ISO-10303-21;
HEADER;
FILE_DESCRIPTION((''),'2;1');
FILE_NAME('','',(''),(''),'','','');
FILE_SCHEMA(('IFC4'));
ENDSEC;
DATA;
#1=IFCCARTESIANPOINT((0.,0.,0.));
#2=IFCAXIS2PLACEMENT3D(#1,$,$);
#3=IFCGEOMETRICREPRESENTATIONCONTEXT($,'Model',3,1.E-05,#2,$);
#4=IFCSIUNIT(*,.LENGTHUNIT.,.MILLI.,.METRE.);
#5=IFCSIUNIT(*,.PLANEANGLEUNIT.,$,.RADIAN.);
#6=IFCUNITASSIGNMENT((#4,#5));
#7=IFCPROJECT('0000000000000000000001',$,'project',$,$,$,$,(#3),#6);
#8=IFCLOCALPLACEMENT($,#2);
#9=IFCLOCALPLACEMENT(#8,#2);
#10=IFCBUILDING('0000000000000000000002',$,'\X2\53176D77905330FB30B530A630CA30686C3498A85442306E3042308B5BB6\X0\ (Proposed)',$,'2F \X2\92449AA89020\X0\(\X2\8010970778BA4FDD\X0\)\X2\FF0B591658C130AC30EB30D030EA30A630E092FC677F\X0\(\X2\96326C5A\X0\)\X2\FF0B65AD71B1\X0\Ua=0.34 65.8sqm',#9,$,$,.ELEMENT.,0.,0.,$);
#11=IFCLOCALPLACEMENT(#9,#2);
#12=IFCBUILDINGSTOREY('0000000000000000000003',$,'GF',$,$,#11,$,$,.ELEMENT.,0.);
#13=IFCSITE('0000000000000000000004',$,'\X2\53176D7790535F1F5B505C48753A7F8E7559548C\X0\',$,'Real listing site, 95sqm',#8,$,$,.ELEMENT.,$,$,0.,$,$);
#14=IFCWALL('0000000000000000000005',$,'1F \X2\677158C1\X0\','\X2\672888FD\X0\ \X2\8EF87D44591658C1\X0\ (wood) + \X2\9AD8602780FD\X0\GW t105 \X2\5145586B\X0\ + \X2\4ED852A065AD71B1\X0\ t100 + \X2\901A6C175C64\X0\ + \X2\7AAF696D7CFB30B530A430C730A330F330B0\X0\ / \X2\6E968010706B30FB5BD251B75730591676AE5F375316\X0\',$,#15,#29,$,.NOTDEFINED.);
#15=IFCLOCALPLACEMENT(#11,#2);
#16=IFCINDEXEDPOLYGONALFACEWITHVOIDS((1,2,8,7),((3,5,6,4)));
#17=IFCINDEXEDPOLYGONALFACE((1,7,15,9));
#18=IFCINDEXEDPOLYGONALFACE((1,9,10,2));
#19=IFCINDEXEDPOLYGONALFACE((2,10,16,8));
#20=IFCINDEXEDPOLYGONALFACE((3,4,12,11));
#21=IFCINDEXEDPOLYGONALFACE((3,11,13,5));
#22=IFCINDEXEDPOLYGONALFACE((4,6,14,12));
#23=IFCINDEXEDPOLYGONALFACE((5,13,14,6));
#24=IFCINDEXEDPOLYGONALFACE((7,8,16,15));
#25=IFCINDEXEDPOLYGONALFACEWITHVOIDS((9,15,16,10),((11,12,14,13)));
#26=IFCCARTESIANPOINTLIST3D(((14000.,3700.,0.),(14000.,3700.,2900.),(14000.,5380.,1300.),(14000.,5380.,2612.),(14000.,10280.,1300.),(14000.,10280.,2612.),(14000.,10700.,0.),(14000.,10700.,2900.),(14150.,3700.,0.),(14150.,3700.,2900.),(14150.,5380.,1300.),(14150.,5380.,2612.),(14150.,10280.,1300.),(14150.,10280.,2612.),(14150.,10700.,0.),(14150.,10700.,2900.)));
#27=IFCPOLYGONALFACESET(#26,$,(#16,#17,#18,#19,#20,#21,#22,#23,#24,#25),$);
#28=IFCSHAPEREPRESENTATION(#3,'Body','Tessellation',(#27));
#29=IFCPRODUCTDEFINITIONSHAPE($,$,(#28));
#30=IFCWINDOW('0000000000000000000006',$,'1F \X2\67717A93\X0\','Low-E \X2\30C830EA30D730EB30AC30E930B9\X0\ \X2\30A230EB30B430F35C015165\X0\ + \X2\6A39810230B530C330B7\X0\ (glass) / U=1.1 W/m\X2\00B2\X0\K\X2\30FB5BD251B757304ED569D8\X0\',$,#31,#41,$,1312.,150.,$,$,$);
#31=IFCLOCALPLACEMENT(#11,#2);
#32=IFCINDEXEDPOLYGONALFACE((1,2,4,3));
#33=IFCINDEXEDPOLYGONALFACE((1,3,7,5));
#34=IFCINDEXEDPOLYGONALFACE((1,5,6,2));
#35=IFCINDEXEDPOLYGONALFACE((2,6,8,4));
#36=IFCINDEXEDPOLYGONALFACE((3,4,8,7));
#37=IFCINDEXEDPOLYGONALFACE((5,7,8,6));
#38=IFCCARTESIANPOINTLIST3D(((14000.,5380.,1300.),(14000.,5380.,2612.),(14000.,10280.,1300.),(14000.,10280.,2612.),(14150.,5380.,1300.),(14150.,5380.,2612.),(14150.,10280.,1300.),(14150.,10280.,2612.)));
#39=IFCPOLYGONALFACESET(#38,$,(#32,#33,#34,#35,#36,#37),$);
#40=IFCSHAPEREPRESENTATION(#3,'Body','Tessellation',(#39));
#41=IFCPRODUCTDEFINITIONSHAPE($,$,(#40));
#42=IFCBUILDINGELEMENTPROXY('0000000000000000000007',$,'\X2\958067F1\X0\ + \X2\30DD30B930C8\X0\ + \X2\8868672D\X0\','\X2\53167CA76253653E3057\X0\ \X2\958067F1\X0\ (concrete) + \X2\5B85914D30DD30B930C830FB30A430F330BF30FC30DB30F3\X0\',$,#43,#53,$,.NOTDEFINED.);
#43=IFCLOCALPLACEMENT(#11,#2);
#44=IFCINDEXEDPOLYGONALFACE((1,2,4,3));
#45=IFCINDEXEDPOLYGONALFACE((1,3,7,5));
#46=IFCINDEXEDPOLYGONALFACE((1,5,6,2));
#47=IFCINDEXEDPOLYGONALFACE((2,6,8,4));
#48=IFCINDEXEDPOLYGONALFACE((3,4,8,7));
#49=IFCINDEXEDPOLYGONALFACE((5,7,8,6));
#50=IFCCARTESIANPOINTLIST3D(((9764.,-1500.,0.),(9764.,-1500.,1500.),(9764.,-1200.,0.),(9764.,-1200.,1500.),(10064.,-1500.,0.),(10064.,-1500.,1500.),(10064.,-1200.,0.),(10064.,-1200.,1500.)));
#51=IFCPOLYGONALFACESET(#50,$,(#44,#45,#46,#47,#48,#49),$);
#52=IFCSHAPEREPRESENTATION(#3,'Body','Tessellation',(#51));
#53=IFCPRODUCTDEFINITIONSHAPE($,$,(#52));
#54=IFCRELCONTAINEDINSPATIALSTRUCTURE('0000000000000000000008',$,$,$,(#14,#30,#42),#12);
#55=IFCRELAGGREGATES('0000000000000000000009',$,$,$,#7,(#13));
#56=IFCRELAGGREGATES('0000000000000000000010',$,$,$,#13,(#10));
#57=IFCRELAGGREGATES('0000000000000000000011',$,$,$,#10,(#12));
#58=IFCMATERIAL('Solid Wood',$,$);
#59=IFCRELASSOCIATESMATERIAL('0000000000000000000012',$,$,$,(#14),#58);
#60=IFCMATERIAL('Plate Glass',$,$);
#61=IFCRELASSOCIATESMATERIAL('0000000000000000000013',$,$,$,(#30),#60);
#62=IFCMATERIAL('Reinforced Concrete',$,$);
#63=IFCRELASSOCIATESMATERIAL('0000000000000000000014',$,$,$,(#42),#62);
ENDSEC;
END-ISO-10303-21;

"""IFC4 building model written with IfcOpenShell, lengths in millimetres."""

from ifc_helpers import new_model, si_unit, frame, frame_2d, origin, place, context, project, spatial, rectangle, extrude, material, element, fill, save


model = new_model("IFC4")

# Units and contexts
model_context = context("Model", 3, precision=1e-05, world=origin())
ifc_project = project(units=[si_unit("LENGTHUNIT", "METRE", prefix="MILLI"), si_unit("PLANEANGLEUNIT", "RADIAN")], contexts=[model_context])

# Site, building, storey
site_placement = place(None, origin())
site = spatial("IfcSite", under=ifc_project, at=site_placement, Name="北海道弟子屈町美留和", ObjectType="Real listing site, 95sqm", CompositionType="ELEMENT", RefElevation=0.0)
building_placement = place(site_placement, origin())
building = spatial("IfcBuilding", under=site, at=building_placement, Name="北海道・サウナと水風呂のある家 (Proposed)", ObjectType="2F 鉄骨造(耐震確保)＋外壁ガルバリウム鋼板(防汚)＋断熱Ua=0.34 65.8sqm", CompositionType="ELEMENT", ElevationOfRefHeight=0.0, ElevationOfTerrain=0.0)
storey_placement = place(building_placement, origin())
storey = spatial("IfcBuildingStorey", under=building, at=storey_placement, Name="GF", CompositionType="ELEMENT", Elevation=0.0)

# Shared definitions
ifc_material_1 = material(Name="Solid Wood")

# Wall, opening, window
wall_1_placement = place(storey_placement, frame((7000.0, 1850.0, 0.0)))
wall_1 = element("IfcWall", 1, at=wall_1_placement, inside=storey, material=ifc_material_1, Name="1F 東壁", Description="木製 軸組外壁 (wood) + 高性能GW t105 充填 + 付加断熱 t100 + 通気層 + 窯業系サイディング / 準耐火・寒冷地外皮強化", PredefinedType="NOTDEFINED", context=model_context, shape_type="SweptSolid", body=[
    extrude(rectangle(XDim=150.0, YDim=7000.0, at=frame_2d((75.0, 3500.0))), frame((7000.0, 1850.0, 0.0)), (0.0, 0.0, 1.0), 2900.0),
])
opening_1_placement = place(storey_placement, frame((7000.0, 2690.0, 650.0)))
opening_1 = element("IfcOpeningElement", 2, at=opening_1_placement, cuts=wall_1, PredefinedType="NOTDEFINED", context=model_context, shape_type="SweptSolid", body=[
    extrude(rectangle(XDim=150.0, YDim=4900.0, at=frame_2d((75.0, 2450.0))), frame((7000.0, 2690.0, 650.0)), (0.0, 0.0, 1.0), 1312.0),
])
ifc_material_2 = material(Name="Plate Glass")
window_1_placement = place(storey_placement, frame((7000.0, 2690.0, 650.0)))
window_1 = element("IfcWindow", 3, at=window_1_placement, inside=storey, material=ifc_material_2, Name="1F 東窓", Description="Low-E トリプルガラス アルゴン封入 + 樹脂サッシ (glass) / U=1.1 W/m²K・寒冷地仕様", OverallHeight=1312.0, OverallWidth=150.0, context=model_context, shape_type="SweptSolid", body=[
    extrude(rectangle(XDim=150.0, YDim=4900.0, at=frame_2d((75.0, 2450.0))), frame((7000.0, 2690.0, 650.0)), (0.0, 0.0, 1.0), 1312.0),
])
fill(opening_1, window_1)

# Shared definitions
ifc_material_3 = material(Name="Reinforced Concrete")

# Building element proxy
proxy_placement = place(storey_placement, frame((4882.0, -750.0, 0.0)))
element("IfcBuildingElementProxy", 4, at=proxy_placement, inside=storey, material=ifc_material_3, Name="門柱 + ポスト + 表札", Description="化粧打放し 門柱 (concrete) + 宅配ポスト・インターホン", PredefinedType="NOTDEFINED", context=model_context, shape_type="SweptSolid", body=[
    extrude(rectangle(XDim=300.0, YDim=300.0, at=frame_2d((150.0, 150.0))), frame((4882.0, -750.0, 0.0)), (0.0, 0.0, 1.0), 1500.0),
])

save(model, "model.ifc")
